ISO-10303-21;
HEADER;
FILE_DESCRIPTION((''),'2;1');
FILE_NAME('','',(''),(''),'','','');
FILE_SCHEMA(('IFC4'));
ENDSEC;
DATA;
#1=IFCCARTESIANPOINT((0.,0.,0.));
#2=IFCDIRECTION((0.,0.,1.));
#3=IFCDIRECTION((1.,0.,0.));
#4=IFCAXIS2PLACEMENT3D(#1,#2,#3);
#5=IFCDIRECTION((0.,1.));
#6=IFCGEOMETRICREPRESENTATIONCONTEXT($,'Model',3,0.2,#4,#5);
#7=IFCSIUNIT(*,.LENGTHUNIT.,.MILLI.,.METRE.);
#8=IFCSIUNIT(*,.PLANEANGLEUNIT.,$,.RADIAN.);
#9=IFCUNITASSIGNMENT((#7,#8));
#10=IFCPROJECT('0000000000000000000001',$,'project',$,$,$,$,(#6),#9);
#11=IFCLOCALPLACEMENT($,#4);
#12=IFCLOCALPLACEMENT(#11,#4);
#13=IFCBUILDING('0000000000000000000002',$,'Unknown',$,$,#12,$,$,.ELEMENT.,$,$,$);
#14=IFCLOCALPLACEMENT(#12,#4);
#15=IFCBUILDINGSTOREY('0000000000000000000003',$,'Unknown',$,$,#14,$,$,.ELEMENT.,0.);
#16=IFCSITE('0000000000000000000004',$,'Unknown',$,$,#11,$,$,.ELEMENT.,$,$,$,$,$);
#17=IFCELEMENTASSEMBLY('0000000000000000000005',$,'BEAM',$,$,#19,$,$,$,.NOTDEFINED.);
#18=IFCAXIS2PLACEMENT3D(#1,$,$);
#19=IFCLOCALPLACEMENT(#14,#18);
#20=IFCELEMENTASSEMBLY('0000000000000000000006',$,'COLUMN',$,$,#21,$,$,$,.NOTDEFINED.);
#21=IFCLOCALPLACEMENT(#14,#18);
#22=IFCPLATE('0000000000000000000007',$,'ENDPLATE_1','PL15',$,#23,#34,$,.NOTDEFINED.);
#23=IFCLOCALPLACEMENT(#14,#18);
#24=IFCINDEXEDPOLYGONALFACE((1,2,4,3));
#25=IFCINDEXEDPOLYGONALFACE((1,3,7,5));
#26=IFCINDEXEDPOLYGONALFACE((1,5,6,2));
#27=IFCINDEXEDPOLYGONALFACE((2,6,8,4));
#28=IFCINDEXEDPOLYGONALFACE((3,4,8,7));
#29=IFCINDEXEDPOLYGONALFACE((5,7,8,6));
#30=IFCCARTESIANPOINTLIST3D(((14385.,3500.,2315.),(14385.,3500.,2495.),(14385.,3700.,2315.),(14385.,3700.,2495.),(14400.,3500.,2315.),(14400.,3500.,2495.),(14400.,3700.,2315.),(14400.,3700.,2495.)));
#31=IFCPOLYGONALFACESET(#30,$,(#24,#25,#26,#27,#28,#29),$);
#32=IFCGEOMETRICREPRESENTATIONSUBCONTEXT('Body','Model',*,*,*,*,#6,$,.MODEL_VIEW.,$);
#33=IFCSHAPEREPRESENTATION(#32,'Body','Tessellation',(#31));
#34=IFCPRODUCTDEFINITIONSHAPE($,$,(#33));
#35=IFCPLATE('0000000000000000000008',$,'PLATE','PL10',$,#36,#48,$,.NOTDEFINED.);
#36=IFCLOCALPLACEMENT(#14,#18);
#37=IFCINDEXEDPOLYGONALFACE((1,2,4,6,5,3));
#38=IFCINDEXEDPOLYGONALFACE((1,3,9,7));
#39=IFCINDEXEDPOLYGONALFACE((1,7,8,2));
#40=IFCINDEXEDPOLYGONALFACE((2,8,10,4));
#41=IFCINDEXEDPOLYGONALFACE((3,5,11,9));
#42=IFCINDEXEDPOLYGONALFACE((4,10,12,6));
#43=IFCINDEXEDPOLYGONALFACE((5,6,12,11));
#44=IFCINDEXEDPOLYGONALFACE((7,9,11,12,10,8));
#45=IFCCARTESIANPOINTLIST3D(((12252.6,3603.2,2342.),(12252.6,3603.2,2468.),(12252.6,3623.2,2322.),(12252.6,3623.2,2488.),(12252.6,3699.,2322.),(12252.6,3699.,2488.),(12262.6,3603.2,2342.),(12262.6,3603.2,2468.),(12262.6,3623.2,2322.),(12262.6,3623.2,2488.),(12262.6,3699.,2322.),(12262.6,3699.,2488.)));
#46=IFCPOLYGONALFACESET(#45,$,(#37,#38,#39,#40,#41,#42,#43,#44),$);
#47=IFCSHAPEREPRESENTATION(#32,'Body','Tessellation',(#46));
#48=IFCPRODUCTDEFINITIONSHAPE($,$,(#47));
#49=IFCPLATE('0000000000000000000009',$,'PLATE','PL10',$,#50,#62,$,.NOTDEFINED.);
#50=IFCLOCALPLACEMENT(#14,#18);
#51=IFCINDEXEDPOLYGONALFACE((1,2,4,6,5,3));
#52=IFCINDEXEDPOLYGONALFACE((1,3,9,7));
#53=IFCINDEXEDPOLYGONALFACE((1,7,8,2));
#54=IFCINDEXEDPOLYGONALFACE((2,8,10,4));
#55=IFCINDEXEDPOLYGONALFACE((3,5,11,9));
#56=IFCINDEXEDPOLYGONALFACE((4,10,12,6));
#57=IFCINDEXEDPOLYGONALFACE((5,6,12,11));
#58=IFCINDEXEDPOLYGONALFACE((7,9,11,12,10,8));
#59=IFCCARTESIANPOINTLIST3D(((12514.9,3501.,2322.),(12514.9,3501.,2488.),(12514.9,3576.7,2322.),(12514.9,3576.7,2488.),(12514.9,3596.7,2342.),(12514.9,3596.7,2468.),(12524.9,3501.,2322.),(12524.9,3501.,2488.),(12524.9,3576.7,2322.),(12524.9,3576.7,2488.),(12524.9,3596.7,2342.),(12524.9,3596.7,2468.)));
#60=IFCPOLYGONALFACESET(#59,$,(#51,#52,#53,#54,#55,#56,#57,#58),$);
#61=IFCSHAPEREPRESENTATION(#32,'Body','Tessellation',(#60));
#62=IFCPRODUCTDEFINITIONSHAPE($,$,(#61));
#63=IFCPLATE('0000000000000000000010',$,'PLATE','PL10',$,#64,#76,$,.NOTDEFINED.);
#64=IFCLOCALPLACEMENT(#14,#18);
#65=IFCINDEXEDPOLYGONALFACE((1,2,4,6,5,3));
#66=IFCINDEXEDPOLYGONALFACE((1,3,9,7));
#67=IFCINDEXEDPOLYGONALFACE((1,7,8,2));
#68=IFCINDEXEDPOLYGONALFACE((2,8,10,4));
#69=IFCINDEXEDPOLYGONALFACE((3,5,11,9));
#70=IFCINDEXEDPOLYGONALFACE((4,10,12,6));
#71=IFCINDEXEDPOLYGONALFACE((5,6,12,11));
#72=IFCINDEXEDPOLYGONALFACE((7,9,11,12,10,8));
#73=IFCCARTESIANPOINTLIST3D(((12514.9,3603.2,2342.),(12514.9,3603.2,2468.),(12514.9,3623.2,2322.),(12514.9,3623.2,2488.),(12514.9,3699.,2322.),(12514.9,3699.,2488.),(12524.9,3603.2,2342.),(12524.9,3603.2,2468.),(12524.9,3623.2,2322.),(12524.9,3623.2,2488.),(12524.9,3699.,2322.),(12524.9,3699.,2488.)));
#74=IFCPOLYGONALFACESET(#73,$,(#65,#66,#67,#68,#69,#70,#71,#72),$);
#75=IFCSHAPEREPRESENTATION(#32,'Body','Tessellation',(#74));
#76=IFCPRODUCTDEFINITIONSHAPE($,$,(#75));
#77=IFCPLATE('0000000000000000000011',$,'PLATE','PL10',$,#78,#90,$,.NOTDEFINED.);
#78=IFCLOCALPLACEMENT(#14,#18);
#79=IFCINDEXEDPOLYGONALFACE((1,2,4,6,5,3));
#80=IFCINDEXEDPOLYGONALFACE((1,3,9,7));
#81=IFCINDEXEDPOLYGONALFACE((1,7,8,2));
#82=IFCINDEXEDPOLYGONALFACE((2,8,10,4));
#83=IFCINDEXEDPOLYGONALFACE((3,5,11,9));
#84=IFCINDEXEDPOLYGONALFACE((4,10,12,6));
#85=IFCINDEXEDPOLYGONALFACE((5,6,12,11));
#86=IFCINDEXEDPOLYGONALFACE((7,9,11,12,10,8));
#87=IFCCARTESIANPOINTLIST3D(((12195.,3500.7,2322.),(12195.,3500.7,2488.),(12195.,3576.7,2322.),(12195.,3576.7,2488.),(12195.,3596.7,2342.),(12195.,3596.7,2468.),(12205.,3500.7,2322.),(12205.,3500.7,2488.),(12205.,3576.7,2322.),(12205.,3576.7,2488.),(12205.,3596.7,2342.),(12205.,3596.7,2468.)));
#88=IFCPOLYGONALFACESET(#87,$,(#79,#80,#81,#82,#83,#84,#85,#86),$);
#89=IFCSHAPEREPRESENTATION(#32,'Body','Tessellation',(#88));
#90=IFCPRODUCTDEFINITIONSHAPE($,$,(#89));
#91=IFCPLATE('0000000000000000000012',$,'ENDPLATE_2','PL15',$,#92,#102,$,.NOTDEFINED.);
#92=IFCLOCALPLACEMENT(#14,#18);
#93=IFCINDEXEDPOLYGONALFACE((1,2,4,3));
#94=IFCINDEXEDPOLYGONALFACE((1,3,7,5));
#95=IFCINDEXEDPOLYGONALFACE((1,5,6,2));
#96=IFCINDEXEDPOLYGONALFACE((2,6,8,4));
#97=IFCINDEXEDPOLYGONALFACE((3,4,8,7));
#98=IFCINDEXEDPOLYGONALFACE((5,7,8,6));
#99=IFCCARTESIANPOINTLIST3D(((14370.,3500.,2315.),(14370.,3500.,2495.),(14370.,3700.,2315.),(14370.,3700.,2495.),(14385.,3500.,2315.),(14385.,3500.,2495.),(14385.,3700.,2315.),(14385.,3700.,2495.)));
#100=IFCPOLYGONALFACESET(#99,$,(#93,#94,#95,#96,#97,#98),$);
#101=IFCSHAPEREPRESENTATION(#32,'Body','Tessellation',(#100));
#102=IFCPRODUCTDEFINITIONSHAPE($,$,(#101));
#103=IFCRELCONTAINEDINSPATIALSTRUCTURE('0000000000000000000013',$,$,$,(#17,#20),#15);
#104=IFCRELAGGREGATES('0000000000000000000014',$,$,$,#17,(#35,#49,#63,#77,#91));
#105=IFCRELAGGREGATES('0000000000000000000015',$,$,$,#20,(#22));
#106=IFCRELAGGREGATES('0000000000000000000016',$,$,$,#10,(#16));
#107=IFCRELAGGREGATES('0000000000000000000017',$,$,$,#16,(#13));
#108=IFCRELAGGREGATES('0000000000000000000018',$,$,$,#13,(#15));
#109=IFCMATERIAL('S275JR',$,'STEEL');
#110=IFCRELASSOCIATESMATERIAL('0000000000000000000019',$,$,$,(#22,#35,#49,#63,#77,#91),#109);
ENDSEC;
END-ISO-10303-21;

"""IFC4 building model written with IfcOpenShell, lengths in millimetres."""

from ifc_helpers import new_model, si_unit, direction, frame, origin_with_axes, place, context, subcontext, project, spatial, line, indexed_curve, outline, extrude, material, element, aggregate, save


model = new_model("IFC4")

# Units and contexts
model_context = context("Model", 3, precision=0.2, world=origin_with_axes(), true_north=direction((0.0, 1.0)))
body_context = subcontext(model_context, "Body", "Model", "MODEL_VIEW")
ifc_project = project(units=[si_unit("LENGTHUNIT", "METRE", prefix="MILLI"), si_unit("PLANEANGLEUNIT", "RADIAN")], contexts=[model_context])

# Site, building, storey
site_placement = place(None, origin_with_axes())
site = spatial("IfcSite", under=ifc_project, at=site_placement, Name="Unknown", CompositionType="ELEMENT")
building_placement = place(site_placement, origin_with_axes())
building = spatial("IfcBuilding", under=site, at=building_placement, Name="Unknown", CompositionType="ELEMENT")
storey_placement = place(building_placement, origin_with_axes())
storey = spatial("IfcBuildingStorey", under=building, at=storey_placement, Name="Unknown", CompositionType="ELEMENT", Elevation=0.0)

# Element assembly
ifc_material_1 = material(Name="S275JR", Category="STEEL")
assembly_1_placement = place(storey_placement, frame((9800.0, 3600.0, 2405.0), z_axis=(-0.000002, -1.0, 0.0), x_axis=(1.0, 0.0, 0.0)))
assembly_1 = element("IfcElementAssembly", 1, at=assembly_1_placement, inside=storey, Name="BEAM", PredefinedType="NOTDEFINED")

# Element assembly, plate
assembly_2_placement = place(storey_placement, frame((14600.0, 3600.0, 200.0), z_axis=(-1.0, 0.0, 0.0), x_axis=(0.0, 0.0, 1.0)))
assembly_2 = element("IfcElementAssembly", 2, at=assembly_2_placement, inside=storey, Name="COLUMN", PredefinedType="NOTDEFINED")
plate_1_placement = place(assembly_2_placement, frame((2115.0, -100.0, 207.5), z_axis=(0.0, 0.0, 1.0), x_axis=(1.0, 0.0, 0.0)))
plate_1 = element("IfcPlate", 3, at=plate_1_placement, material=ifc_material_1, Name="ENDPLATE_1", Description="PL15", PredefinedType="NOTDEFINED", context=body_context, shape_type="SolidModel", body=[
    extrude(outline(indexed_curve([(0.0, 0.0), (180.0, 0.0), (180.0, 200.0), (0.0, 200.0)], segments=[line(1, 2, 3, 4, 1)])), frame((0.0, 0.0, 7.5), z_axis=(0.0, 0.0, 1.0), x_axis=(1.0, 0.0, 0.0)), (0.0, -0.000002, -1.0), 15.0),
])

# Plates
plate_2_placement = place(assembly_1_placement, frame((2457.6, -83.0, -3.2), z_axis=(1.0, 0.0, 0.0), x_axis=(0.0, -0.000002, -1.0)))
plate_2 = element("IfcPlate", 4, at=plate_2_placement, material=ifc_material_1, Name="PLATE", Description="PL10", PredefinedType="NOTDEFINED", context=body_context, shape_type="SolidModel", body=[
    extrude(outline(indexed_curve([(0.0, 20.0), (20.0, 0.0), (95.8, 0.0), (95.8, 166.0), (20.0, 166.0), (0.0, 146.0)], segments=[line(1, 2, 3, 4, 5, 6, 1)])), frame((0.0, 0.0, 5.0), z_axis=(0.0, 0.0, 1.0), x_axis=(1.0, 0.0, 0.0)), (0.0, -0.000002, -1.0), 10.0),
])
plate_3_placement = place(assembly_1_placement, frame((2719.9, -83.0, 99.0), z_axis=(1.0, 0.0, 0.0), x_axis=(0.0, -0.000002, -1.0)))
plate_3 = element("IfcPlate", 5, at=plate_3_placement, material=ifc_material_1, Name="PLATE", Description="PL10", PredefinedType="NOTDEFINED", context=body_context, shape_type="SolidModel", body=[
    extrude(outline(indexed_curve([(0.0, 0.0), (75.8, 0.0), (95.8, 20.0), (95.8, 146.0), (75.8, 166.0), (0.0, 166.0)], segments=[line(1, 2, 3, 4, 5, 6, 1)])), frame((0.0, 0.0, 5.0), z_axis=(0.0, 0.0, 1.0), x_axis=(1.0, 0.0, 0.0)), (0.0, -0.000002, -1.0), 10.0),
])
plate_4_placement = place(assembly_1_placement, frame((2719.9, -83.0, -3.2), z_axis=(1.0, 0.0, 0.0), x_axis=(0.0, -0.000002, -1.0)))
plate_4 = element("IfcPlate", 6, at=plate_4_placement, material=ifc_material_1, Name="PLATE", Description="PL10", PredefinedType="NOTDEFINED", context=body_context, shape_type="SolidModel", body=[
    extrude(outline(indexed_curve([(0.0, 20.0), (20.0, 0.0), (95.8, 0.0), (95.8, 166.0), (20.0, 166.0), (0.0, 146.0)], segments=[line(1, 2, 3, 4, 5, 6, 1)])), frame((0.0, 0.0, 5.0), z_axis=(0.0, 0.0, 1.0), x_axis=(1.0, 0.0, 0.0)), (0.0, -0.000002, -1.0), 10.0),
])
plate_5_placement = place(assembly_1_placement, frame((2400.0, -83.0, 3.2), z_axis=(-1.0, 0.0, 0.0), x_axis=(0.0, 0.0, 1.0)))
plate_5 = element("IfcPlate", 7, at=plate_5_placement, material=ifc_material_1, Name="PLATE", Description="PL10", PredefinedType="NOTDEFINED", context=body_context, shape_type="SolidModel", body=[
    extrude(outline(indexed_curve([(0.0, 20.0), (20.0, 0.0), (96.0, 0.0), (96.0, 166.0), (20.0, 166.0), (0.0, 146.0)], segments=[line(1, 2, 3, 4, 5, 6, 1)])), frame((0.0, 0.0, 5.0), z_axis=(0.0, 0.0, 1.0), x_axis=(1.0, 0.0, 0.0)), (0.0, -0.000002, -1.0), 10.0),
])
plate_6_placement = place(assembly_1_placement, frame((4577.5, -90.0, 100.0), z_axis=(-1.0, 0.0, 0.0), x_axis=(0.0, 1.0, 0.0)))
plate_6 = element("IfcPlate", 8, at=plate_6_placement, material=ifc_material_1, Name="ENDPLATE_2", Description="PL15", PredefinedType="NOTDEFINED", context=body_context, shape_type="SolidModel", body=[
    extrude(outline(indexed_curve([(0.0, 0.0), (180.0, 0.0), (180.0, 200.0), (0.0, 200.0)], segments=[line(1, 2, 3, 4, 1)])), frame((0.0, 0.0, 7.5), z_axis=(0.0, 0.0, 1.0), x_axis=(1.0, 0.0, 0.0)), (0.0, -0.000002, -1.0), 15.0),
])

aggregate(assembly_1, [plate_2, plate_3, plate_4, plate_5, plate_6])
aggregate(assembly_2, [plate_1])

save(model, "model.ifc")
